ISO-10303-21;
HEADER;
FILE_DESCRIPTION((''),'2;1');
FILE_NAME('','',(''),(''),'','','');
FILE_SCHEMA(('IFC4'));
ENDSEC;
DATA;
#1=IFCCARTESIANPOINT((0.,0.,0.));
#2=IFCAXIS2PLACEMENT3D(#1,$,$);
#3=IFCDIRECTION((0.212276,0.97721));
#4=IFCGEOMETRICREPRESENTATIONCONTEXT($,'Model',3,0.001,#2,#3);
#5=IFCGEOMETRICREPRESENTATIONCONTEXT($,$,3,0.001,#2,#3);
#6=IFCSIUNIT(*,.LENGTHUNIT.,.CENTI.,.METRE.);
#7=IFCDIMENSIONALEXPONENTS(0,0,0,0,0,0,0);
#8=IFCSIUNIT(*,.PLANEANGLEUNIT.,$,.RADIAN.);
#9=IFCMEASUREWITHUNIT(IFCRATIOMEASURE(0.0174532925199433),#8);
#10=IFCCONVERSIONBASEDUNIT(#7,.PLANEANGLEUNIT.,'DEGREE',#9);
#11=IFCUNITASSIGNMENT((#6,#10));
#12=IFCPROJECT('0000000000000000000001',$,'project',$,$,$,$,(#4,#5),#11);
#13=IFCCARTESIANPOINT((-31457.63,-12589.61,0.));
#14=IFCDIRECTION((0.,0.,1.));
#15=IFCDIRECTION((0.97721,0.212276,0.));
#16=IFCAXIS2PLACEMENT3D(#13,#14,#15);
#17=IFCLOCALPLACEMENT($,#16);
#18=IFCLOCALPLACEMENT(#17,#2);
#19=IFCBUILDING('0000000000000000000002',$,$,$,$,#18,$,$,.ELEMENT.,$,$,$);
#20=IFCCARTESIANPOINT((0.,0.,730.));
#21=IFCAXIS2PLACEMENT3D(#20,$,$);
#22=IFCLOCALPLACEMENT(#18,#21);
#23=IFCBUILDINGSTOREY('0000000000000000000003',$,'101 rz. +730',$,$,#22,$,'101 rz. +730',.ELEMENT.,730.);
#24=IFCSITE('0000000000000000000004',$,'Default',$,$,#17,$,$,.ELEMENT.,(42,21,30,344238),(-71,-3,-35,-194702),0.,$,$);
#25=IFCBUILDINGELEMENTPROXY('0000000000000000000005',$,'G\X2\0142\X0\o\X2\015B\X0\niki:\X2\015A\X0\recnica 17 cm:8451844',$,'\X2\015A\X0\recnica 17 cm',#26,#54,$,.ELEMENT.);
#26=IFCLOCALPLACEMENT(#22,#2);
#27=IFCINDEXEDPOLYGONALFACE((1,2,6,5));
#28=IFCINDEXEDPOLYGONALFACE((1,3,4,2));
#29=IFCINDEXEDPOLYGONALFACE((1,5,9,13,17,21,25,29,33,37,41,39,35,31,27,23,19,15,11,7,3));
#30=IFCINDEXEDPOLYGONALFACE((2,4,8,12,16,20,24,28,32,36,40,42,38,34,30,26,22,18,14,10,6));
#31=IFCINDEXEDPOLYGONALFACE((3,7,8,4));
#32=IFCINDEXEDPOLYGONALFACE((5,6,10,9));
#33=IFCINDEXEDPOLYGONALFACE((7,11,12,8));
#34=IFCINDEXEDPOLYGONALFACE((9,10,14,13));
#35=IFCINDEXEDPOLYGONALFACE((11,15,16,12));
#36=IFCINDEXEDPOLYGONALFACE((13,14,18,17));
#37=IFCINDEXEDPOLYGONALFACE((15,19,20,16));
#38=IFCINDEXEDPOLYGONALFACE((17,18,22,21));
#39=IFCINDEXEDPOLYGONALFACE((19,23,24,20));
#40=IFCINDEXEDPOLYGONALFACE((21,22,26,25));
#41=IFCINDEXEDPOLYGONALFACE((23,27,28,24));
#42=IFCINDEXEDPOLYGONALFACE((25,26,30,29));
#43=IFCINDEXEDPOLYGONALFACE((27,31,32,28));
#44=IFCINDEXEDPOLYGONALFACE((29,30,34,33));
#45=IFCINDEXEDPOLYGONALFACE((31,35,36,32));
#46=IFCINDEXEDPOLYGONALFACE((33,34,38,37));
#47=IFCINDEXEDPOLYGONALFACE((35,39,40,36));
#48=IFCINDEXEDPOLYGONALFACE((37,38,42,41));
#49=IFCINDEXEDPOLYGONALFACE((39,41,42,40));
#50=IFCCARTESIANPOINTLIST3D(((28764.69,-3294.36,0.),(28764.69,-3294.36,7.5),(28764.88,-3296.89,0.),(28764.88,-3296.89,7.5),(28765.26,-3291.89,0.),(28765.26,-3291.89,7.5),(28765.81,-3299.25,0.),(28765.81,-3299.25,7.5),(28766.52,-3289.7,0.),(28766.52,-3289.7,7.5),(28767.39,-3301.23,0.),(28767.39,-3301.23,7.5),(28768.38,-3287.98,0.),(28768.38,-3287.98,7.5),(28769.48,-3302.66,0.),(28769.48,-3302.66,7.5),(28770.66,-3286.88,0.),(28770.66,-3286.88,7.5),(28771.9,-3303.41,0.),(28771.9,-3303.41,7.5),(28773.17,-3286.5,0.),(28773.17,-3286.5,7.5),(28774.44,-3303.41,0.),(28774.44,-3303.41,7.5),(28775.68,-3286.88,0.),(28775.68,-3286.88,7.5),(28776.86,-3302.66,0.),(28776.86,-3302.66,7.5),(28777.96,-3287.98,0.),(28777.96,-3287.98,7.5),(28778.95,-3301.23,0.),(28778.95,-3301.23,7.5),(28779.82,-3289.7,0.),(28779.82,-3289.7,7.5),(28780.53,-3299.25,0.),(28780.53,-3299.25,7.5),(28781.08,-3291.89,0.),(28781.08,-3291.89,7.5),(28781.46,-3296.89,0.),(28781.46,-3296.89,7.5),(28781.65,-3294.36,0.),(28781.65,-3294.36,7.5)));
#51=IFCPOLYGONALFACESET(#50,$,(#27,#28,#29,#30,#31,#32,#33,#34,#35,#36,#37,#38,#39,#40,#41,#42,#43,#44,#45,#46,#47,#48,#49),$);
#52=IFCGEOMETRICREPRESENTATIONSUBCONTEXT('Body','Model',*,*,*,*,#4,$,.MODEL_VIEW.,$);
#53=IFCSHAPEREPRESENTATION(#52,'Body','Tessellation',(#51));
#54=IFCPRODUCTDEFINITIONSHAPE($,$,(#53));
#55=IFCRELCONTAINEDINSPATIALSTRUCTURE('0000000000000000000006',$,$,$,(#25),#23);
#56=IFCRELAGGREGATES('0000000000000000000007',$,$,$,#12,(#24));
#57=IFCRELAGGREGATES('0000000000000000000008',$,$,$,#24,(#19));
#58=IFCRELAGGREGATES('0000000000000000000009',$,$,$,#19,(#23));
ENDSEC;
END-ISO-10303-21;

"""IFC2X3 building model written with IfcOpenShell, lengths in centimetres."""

from ifc_helpers import new_model, entity, si_unit, converted_unit, direction, frame, frame_2d, origin, place, context, subcontext, project, spatial, circle, extrude, source, transform, mapped, element, save


model = new_model("IFC2X3")

# Units and contexts
model_context = context("Model", 3, precision=0.001, world=origin(), true_north=direction((0.212276, 0.97721)))
context_of_model = context(None, 3, precision=0.001, world=origin(), true_north=direction((0.212276, 0.97721)))
body_context = subcontext(model_context, "Body", "Model", "MODEL_VIEW")
ifc_project = project(units=[si_unit("LENGTHUNIT", "METRE", prefix="CENTI"), converted_unit("PLANEANGLEUNIT", "DEGREE", entity("IfcRatioMeasure", 0.0174532925199433), si_unit("PLANEANGLEUNIT", "RADIAN"), dimensions=[0, 0, 0, 0, 0, 0, 0])], contexts=[model_context, context_of_model])

# Site, building, storey
site_placement = place(None, frame((-31457.63, -12589.61, 0.0), z_axis=(0.0, 0.0, 1.0), x_axis=(0.97721, 0.212276, 0.0)))
site = spatial("IfcSite", under=ifc_project, at=site_placement, Name="Default", CompositionType="ELEMENT", RefLatitude=(42, 21, 30, 344238), RefLongitude=(-71, -3, -35, -194702), RefElevation=0.0)
building_placement = place(site_placement, origin())
building = spatial("IfcBuilding", under=site, at=building_placement, CompositionType="ELEMENT")
storey_placement = place(building_placement, frame((0.0, 0.0, 730.0)))
storey = spatial("IfcBuildingStorey", under=building, at=storey_placement, Name="101 rz. +730", LongName="101 rz. +730", CompositionType="ELEMENT", Elevation=730.0)

# Building element proxy
shared_shape_1 = source(origin(), body_context, "Body", "SweptSolid", [
    extrude(circle(Radius=8.5, at=frame_2d((0.0, 0.0), x_axis=(1.0, 0.0))), frame((0.0, 0.0, 0.0), z_axis=(0.0, 0.0, 1.0), x_axis=(0.0, 1.0, 0.0)), (0.0, 0.0, 1.0), 7.5),
])
for number, where, name in (
    (1, (28773.17, -3295.0, 0.0), "Głośniki:Śrecnica 17 cm:8451844"),
):
    element("IfcBuildingElementProxy", number, at=place(storey_placement, frame(where)), inside=storey, Name=name, ObjectType="Śrecnica 17 cm", CompositionType="ELEMENT", context=body_context, shape_type="MappedRepresentation", body=[
        mapped(shared_shape_1, transform((0.0, 0.0, 0.0), scale=1.0)),
    ])

save(model, "model.ifc")
